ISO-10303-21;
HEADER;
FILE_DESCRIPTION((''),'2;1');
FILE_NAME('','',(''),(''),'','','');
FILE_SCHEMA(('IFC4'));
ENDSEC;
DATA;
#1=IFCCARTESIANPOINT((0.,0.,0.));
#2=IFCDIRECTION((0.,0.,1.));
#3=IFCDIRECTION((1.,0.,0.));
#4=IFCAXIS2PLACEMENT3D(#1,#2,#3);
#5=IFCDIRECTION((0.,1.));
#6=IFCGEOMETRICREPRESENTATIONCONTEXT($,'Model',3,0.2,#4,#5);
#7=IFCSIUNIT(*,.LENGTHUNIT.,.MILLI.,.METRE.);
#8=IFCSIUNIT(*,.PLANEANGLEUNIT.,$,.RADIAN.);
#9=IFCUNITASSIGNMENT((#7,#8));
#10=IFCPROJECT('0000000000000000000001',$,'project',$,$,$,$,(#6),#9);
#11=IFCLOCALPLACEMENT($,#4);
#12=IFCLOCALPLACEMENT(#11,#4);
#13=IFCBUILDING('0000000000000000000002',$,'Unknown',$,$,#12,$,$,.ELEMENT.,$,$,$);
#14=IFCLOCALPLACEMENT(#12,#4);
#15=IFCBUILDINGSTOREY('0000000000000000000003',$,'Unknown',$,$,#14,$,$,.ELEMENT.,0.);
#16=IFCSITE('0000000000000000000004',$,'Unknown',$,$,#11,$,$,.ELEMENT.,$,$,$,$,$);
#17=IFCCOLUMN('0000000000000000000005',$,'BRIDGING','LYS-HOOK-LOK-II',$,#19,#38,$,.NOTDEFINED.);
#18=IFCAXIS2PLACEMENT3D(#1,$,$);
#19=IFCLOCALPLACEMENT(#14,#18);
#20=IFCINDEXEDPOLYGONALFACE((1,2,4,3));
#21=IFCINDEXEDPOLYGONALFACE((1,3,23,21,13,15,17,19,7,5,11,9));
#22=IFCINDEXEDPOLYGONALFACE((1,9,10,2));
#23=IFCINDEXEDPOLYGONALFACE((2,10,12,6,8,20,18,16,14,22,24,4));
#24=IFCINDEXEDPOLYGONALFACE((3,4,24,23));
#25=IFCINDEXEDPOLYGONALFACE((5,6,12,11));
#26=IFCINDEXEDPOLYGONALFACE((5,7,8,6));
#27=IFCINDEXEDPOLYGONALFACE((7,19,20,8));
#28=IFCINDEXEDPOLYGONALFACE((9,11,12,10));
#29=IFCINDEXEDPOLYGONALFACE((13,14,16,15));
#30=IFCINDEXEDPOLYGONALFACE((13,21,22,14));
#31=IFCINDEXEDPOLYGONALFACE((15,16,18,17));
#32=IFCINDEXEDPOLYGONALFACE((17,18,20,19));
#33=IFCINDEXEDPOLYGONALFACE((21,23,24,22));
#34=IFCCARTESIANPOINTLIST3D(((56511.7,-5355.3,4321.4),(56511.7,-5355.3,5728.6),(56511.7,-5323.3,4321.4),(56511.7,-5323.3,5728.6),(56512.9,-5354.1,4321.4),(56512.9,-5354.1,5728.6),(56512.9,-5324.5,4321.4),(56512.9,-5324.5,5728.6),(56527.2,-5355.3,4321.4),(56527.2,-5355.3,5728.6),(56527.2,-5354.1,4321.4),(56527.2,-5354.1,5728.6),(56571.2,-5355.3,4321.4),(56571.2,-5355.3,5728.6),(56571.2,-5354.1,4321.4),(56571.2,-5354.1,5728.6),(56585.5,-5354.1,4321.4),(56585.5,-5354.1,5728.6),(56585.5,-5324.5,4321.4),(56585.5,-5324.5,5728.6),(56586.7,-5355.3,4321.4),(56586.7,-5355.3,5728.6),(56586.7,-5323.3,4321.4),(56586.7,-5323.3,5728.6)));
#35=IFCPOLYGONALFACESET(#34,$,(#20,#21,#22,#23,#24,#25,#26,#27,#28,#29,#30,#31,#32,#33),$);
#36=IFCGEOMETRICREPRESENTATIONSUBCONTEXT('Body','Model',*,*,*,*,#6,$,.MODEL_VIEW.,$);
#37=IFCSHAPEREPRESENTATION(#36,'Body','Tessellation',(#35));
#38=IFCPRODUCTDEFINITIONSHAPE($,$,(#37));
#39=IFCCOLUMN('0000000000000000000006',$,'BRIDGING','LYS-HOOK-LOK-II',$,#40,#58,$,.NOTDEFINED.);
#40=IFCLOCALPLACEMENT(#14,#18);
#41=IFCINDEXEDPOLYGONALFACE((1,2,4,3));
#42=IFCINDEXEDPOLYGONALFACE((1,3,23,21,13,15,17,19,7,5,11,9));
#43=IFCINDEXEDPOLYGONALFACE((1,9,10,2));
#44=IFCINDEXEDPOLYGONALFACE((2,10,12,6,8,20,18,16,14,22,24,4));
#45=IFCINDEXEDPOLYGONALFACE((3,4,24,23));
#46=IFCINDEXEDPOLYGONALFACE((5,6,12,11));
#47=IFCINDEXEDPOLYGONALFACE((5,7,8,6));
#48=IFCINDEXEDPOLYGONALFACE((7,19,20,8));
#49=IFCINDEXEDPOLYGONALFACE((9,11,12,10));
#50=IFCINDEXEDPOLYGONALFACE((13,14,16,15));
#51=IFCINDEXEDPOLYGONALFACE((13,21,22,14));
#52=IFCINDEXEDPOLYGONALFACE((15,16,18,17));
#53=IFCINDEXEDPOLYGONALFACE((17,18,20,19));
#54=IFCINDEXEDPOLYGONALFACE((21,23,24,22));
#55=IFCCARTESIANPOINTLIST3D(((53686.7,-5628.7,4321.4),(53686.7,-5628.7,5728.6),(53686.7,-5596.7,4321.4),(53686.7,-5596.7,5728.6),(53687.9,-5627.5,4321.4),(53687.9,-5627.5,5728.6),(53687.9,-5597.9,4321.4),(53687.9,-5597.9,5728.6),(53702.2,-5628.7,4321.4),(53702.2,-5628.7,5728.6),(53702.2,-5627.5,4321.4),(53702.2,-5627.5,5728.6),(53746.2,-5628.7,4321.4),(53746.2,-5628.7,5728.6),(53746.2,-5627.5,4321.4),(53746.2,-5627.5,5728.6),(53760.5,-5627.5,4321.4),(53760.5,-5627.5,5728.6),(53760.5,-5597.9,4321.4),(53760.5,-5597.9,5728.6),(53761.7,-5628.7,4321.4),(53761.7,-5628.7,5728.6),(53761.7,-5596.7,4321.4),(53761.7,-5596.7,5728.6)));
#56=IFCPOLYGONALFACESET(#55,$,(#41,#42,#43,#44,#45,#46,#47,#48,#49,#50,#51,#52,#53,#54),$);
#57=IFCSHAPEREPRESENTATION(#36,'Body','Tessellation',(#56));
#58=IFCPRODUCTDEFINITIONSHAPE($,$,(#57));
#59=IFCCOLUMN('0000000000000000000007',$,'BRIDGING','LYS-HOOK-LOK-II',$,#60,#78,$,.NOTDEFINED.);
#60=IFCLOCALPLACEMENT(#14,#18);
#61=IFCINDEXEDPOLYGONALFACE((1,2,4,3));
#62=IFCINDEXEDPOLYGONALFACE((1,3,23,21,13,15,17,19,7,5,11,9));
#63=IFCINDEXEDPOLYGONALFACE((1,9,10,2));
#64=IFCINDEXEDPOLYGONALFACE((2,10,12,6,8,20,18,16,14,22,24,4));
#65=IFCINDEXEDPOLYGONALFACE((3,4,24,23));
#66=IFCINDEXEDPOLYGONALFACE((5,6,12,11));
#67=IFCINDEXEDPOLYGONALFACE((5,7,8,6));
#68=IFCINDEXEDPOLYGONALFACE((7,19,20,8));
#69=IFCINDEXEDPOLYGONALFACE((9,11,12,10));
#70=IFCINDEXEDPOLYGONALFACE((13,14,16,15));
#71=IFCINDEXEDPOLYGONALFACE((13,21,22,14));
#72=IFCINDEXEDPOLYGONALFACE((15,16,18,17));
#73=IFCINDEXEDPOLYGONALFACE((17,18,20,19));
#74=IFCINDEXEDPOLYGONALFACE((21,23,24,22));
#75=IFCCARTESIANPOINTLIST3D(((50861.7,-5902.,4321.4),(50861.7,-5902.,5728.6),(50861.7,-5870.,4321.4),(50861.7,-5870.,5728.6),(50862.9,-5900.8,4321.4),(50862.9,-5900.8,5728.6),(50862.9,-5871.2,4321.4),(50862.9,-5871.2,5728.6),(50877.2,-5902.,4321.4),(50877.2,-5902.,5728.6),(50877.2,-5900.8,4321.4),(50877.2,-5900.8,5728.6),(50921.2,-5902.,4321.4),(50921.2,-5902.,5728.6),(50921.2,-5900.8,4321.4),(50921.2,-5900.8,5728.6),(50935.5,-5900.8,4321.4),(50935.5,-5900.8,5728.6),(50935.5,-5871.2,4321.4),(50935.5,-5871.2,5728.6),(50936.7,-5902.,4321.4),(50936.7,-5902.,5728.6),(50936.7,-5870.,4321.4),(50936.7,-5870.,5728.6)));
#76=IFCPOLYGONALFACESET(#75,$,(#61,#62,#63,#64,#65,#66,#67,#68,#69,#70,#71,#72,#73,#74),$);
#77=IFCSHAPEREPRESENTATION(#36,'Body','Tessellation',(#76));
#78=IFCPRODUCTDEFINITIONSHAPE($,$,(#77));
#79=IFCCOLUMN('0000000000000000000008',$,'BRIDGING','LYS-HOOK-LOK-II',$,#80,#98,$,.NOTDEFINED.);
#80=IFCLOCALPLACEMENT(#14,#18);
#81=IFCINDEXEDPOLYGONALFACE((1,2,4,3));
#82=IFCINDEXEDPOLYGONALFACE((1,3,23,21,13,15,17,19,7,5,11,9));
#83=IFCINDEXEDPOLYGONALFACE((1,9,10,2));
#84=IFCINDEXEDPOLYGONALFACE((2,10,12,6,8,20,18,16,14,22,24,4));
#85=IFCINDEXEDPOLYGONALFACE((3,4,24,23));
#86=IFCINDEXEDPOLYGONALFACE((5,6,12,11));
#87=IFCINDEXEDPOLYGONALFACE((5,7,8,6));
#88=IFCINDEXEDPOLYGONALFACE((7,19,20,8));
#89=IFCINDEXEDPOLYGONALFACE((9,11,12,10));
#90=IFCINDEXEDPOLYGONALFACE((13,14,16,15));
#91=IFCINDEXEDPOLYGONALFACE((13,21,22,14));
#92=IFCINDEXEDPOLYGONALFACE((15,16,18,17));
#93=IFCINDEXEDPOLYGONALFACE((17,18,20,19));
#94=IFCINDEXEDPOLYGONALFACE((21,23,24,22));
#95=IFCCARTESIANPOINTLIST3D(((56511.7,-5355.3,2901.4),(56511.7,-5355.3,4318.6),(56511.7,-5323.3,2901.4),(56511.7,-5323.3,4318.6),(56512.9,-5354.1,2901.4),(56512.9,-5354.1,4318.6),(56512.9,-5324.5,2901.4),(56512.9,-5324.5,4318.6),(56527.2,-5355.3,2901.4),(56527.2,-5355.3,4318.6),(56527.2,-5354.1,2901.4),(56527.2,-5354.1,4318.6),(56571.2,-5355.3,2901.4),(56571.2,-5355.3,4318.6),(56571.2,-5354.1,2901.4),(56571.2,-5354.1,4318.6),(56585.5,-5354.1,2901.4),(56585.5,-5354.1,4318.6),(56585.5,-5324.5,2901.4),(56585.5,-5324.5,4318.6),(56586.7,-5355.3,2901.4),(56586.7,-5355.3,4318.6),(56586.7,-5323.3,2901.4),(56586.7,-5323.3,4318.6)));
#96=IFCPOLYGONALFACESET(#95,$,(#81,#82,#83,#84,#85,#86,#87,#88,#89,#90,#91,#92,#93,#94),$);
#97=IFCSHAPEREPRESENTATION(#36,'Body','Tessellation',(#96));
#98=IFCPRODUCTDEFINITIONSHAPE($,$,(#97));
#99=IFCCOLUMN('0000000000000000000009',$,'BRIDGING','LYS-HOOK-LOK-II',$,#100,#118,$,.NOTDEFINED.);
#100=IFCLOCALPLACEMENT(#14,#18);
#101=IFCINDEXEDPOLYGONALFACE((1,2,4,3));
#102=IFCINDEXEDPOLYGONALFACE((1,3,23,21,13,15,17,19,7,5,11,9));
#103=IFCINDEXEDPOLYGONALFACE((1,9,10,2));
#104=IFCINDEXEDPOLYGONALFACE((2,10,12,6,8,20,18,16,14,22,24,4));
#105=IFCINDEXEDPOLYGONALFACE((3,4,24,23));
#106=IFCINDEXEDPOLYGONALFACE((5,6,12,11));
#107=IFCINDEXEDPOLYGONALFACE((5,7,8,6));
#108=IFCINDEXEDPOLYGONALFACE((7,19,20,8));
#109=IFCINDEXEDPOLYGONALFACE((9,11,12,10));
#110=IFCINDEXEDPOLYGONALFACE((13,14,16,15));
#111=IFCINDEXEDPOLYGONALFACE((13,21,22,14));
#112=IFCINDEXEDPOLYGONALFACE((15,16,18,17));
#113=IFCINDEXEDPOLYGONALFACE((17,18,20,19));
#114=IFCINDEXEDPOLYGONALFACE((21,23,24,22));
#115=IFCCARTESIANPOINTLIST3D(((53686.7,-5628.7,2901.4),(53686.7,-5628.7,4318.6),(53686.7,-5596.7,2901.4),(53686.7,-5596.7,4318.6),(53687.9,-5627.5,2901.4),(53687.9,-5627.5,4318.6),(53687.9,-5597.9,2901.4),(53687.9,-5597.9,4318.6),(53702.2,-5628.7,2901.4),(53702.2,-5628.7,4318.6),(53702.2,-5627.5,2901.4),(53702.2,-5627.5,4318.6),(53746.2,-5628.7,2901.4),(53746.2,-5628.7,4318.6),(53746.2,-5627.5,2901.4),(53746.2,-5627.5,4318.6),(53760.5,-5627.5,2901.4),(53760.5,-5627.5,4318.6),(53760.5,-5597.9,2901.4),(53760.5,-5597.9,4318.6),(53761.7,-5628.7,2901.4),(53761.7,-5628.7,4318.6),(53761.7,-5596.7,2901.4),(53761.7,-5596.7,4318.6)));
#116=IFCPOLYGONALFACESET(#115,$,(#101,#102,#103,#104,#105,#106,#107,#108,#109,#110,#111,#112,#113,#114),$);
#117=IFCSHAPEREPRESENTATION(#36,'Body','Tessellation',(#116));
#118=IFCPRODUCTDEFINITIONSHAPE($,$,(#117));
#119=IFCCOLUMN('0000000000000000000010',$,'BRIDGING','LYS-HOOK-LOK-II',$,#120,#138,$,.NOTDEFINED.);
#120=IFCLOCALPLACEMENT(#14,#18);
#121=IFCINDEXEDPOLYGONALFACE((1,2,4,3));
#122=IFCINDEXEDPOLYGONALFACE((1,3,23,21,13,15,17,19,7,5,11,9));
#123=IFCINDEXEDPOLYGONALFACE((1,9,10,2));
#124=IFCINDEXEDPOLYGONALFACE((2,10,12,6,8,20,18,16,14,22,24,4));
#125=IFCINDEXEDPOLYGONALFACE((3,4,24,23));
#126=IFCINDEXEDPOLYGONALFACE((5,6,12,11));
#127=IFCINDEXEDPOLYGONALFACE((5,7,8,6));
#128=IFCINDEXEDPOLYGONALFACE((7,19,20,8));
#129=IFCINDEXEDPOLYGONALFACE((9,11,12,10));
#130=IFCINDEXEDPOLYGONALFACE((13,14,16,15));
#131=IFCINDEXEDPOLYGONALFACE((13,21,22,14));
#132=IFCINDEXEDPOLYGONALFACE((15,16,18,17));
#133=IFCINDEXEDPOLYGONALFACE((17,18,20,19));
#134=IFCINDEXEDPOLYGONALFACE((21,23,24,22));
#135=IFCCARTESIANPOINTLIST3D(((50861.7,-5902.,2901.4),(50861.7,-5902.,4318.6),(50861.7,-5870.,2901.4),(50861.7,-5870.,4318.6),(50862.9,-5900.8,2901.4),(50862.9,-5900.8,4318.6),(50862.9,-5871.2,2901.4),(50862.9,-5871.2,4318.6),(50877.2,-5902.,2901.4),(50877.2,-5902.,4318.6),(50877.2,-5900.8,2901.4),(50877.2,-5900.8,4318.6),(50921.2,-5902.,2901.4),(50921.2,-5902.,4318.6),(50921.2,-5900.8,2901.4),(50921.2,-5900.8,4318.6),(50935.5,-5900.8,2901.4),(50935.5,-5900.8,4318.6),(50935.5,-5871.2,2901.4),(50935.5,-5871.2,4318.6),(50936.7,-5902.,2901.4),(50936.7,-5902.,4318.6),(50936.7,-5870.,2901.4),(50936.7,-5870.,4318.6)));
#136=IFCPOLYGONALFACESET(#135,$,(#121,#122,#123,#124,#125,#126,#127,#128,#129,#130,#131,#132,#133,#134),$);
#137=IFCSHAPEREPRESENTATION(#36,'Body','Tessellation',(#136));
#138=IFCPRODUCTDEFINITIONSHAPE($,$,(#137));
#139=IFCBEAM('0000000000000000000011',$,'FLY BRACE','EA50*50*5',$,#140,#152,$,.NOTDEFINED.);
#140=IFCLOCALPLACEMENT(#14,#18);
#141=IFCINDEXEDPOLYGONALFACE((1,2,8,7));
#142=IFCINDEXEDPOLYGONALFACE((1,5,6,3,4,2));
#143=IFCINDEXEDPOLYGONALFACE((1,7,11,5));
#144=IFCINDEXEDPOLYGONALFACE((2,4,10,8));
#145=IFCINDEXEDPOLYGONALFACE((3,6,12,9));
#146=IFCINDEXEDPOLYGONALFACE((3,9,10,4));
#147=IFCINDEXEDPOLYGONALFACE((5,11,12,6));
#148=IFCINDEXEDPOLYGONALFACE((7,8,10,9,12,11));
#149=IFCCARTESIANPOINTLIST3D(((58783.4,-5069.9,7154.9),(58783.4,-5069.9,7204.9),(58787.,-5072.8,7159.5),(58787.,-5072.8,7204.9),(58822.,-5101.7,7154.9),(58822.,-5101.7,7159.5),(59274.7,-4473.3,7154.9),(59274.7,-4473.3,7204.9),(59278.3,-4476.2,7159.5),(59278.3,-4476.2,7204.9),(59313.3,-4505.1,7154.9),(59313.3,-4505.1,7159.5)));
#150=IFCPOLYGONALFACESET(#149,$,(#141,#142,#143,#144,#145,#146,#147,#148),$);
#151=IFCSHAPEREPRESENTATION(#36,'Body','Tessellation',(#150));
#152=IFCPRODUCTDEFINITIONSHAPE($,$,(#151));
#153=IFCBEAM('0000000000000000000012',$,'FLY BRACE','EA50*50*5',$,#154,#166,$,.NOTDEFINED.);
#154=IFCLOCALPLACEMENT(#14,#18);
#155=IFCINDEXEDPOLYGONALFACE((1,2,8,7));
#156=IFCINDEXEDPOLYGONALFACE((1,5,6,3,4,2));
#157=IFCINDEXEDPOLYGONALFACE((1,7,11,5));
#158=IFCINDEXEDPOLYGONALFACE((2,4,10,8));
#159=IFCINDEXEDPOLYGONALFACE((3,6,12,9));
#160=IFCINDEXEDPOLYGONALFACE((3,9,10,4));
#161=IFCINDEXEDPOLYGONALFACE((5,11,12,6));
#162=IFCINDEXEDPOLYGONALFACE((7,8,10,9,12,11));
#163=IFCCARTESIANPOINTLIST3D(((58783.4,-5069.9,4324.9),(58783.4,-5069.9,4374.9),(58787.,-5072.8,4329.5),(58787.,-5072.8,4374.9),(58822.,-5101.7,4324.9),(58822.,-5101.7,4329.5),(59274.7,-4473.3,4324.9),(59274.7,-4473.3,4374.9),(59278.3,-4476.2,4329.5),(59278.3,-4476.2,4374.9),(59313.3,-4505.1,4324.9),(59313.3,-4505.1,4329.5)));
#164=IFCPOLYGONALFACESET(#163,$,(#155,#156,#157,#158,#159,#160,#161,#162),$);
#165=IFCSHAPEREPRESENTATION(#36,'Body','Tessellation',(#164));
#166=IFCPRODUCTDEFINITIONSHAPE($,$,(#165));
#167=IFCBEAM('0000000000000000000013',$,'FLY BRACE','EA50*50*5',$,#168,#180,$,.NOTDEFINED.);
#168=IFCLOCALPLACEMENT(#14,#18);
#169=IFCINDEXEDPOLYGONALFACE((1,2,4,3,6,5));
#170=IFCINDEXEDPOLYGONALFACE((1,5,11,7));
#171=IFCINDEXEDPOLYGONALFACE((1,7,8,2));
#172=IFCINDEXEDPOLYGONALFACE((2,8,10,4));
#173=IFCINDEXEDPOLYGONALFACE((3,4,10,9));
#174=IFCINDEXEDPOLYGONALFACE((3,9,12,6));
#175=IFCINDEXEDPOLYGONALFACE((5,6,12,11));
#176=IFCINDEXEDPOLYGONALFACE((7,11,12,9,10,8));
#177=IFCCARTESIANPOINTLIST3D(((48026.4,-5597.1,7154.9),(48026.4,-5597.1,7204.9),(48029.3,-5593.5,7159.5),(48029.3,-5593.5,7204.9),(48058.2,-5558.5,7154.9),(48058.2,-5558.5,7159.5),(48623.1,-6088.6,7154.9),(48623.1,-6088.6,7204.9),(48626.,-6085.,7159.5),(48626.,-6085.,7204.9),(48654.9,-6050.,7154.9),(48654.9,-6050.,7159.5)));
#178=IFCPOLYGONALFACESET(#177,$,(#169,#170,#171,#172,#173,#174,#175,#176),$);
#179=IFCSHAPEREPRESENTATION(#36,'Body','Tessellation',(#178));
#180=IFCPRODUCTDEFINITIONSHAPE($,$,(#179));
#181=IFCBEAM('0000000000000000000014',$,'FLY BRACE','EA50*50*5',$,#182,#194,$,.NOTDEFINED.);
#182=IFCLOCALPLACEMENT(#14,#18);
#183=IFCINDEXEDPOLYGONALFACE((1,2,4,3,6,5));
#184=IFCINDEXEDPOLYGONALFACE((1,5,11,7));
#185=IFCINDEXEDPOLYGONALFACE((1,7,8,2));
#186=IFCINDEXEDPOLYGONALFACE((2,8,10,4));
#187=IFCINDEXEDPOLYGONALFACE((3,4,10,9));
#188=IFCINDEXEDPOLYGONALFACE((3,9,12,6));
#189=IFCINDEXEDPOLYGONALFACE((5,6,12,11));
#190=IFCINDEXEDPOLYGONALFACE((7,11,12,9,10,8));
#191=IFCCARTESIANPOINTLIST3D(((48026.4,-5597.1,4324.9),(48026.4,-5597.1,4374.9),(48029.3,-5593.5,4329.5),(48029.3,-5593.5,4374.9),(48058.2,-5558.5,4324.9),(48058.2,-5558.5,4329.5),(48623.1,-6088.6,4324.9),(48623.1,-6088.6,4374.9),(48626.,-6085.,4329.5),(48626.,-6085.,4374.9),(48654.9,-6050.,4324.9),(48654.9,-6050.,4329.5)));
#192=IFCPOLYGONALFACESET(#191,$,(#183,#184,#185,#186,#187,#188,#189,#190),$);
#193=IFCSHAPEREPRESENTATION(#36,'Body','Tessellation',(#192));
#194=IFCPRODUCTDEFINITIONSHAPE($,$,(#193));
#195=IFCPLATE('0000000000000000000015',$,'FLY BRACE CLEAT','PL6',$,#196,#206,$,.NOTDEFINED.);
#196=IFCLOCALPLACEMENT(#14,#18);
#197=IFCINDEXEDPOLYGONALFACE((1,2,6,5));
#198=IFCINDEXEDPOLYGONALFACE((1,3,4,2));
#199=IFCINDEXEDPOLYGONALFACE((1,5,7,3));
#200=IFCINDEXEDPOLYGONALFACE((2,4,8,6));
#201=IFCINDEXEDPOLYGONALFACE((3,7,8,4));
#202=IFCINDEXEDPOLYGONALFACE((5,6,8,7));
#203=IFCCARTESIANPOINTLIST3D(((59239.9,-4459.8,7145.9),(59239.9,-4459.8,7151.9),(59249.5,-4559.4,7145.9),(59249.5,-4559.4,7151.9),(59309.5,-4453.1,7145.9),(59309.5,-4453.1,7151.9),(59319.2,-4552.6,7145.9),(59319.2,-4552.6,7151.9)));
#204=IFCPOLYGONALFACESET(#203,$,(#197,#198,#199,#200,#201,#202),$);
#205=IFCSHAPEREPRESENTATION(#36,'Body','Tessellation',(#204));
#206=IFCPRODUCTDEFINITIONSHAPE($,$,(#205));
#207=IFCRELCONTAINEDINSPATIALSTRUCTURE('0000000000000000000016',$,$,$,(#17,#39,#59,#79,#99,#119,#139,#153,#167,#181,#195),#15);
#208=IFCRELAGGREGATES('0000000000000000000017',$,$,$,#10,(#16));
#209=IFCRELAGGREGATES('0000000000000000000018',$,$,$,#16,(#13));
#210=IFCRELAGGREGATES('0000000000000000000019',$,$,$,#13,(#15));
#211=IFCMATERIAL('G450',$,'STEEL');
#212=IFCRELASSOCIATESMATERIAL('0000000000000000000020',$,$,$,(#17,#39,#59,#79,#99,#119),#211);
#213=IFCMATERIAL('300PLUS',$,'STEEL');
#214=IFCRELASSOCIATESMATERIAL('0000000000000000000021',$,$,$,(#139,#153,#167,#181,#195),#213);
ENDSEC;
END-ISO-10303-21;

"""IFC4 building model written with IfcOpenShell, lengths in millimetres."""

from ifc_helpers import new_model, si_unit, direction, frame, origin_with_axes, place, context, subcontext, project, spatial, line, indexed_curve, outline, extrude, material, element, save


model = new_model("IFC4")

# Units and contexts
model_context = context("Model", 3, precision=0.2, world=origin_with_axes(), true_north=direction((0.0, 1.0)))
body_context = subcontext(model_context, "Body", "Model", "MODEL_VIEW")
ifc_project = project(units=[si_unit("LENGTHUNIT", "METRE", prefix="MILLI"), si_unit("PLANEANGLEUNIT", "RADIAN")], contexts=[model_context])

# Site, building, storey
site_placement = place(None, origin_with_axes())
site = spatial("IfcSite", under=ifc_project, at=site_placement, Name="Unknown", CompositionType="ELEMENT")
building_placement = place(site_placement, origin_with_axes())
building = spatial("IfcBuilding", under=site, at=building_placement, Name="Unknown", CompositionType="ELEMENT")
storey_placement = place(building_placement, origin_with_axes())
storey = spatial("IfcBuildingStorey", under=building, at=storey_placement, Name="Unknown", CompositionType="ELEMENT", Elevation=0.0)

# Columns
ifc_material_1 = material(Name="G450", Category="STEEL")
for number, where, z_axis, x_axis, name in (
    (1, (56549.2, -5339.3, 4321.4), (0.0, -1.0, 0.0), (0.0, 0.0, 1.0), "BRIDGING"),
    (2, (53724.2, -5612.7, 4321.4), (0.0, -1.0, 0.0), (0.0, 0.0, 1.0), "BRIDGING"),
    (3, (50899.2, -5886.0, 4321.4), (0.0, -1.0, 0.0), (0.0, 0.0, 1.0), "BRIDGING"),
):
    element("IfcColumn", number, at=place(storey_placement, frame(where, z_axis=z_axis, x_axis=x_axis)), inside=storey, material=ifc_material_1, Name=name, Description="LYS-HOOK-LOK-II", PredefinedType="NOTDEFINED", context=body_context, shape_type="SolidModel", body=[
        extrude(outline(indexed_curve([(16.0, -37.5), (16.0, -22.0), (14.8, -22.0), (14.8, -36.3), (-14.8, -36.3), (-14.8, 36.3), (14.8, 36.3), (14.8, 22.0), (16.0, 22.0), (16.0, 37.5), (-16.0, 37.5), (-16.0, -37.5)], segments=[line(1, 2, 3, 4, 5, 6, 7, 8, 9, 10, 11, 12, 1)])), frame((0.0, 0.0, 0.0), z_axis=(-1.0, 0.0, 0.0), x_axis=(0.0, 0.0, 1.0)), (0.0, 0.0, -1.0), 1407.2),
    ])
for number, where, z_axis, x_axis, name in (
    (4, (56549.2, -5339.3, 2901.4), (0.0, -1.0, 0.0), (0.0, 0.0, 1.0), "BRIDGING"),
    (5, (53724.2, -5612.7, 2901.4), (0.0, -1.0, 0.0), (0.0, 0.0, 1.0), "BRIDGING"),
    (6, (50899.2, -5886.0, 2901.4), (0.0, -1.0, 0.0), (0.0, 0.0, 1.0), "BRIDGING"),
):
    element("IfcColumn", number, at=place(storey_placement, frame(where, z_axis=z_axis, x_axis=x_axis)), inside=storey, material=ifc_material_1, Name=name, Description="LYS-HOOK-LOK-II", PredefinedType="NOTDEFINED", context=body_context, shape_type="SolidModel", body=[
        extrude(outline(indexed_curve([(16.0, -37.5), (16.0, -22.0), (14.8, -22.0), (14.8, -36.3), (-14.8, -36.3), (-14.8, 36.3), (14.8, 36.3), (14.8, 22.0), (16.0, 22.0), (16.0, 37.5), (-16.0, 37.5), (-16.0, -37.5)], segments=[line(1, 2, 3, 4, 5, 6, 7, 8, 9, 10, 11, 12, 1)])), frame((0.0, 0.0, 0.0), z_axis=(-1.0, 0.0, 0.0), x_axis=(0.0, 0.0, 1.0)), (0.0, 0.0, -1.0), 1417.2),
    ])

# Beams
ifc_material_2 = material(Name="300PLUS", Category="STEEL")
for number, where, z_axis, x_axis, name in (
    (7, (59294.0, -4489.2, 7179.9), (0.0, 0.0, 1.0), (-0.635694, -0.771941, 0.0), "FLY BRACE"),
    (8, (59294.0, -4489.2, 4349.9), (0.0, 0.0, 1.0), (-0.635694, -0.771941, 0.0), "FLY BRACE"),
):
    element("IfcBeam", number, at=place(storey_placement, frame(where, z_axis=z_axis, x_axis=x_axis)), inside=storey, material=ifc_material_2, Name=name, Description="EA50*50*5", PredefinedType="NOTDEFINED", context=body_context, shape_type="SolidModel", body=[
        extrude(outline(indexed_curve([(-25.0, -25.0), (25.0, -25.0), (25.0, -20.4), (-20.4, -20.4), (-20.4, 25.0), (-25.0, 25.0)], segments=[line(1, 2, 3, 4, 5, 6, 1)])), frame((0.0, 0.0, 0.0), z_axis=(-1.0, 0.0, 0.0), x_axis=(0.0, 0.0, 1.0)), (0.0, 0.0, -1.0), 772.9),
    ])
for number, where, z_axis, x_axis, name in (
    (9, (48042.3, -5577.8, 7179.9), (0.0, 0.0, 1.0), (0.771867, -0.635784, 0.0), "FLY BRACE"),
    (10, (48042.3, -5577.8, 4349.9), (0.0, 0.0, 1.0), (0.771867, -0.635784, 0.0), "FLY BRACE"),
):
    element("IfcBeam", number, at=place(storey_placement, frame(where, z_axis=z_axis, x_axis=x_axis)), inside=storey, material=ifc_material_2, Name=name, Description="EA50*50*5", PredefinedType="NOTDEFINED", context=body_context, shape_type="SolidModel", body=[
        extrude(outline(indexed_curve([(-25.0, -25.0), (25.0, -25.0), (25.0, -20.4), (-20.4, -20.4), (-20.4, 25.0), (-25.0, 25.0)], segments=[line(1, 2, 3, 4, 5, 6, 1)])), frame((0.0, 0.0, 0.0), z_axis=(-1.0, 0.0, 0.0), x_axis=(0.0, 0.0, 1.0)), (0.0, 0.0, -1.0), 773.1),
    ])

# Plate
plate_1_placement = place(storey_placement, frame((59309.5, -4453.1, 7148.9), z_axis=(0.0, 0.0, 1.0), x_axis=(-0.995399, -0.095821, 0.0)))
element("IfcPlate", 11, at=plate_1_placement, inside=storey, material=ifc_material_2, Name="FLY BRACE CLEAT", Description="PL6", PredefinedType="NOTDEFINED", context=body_context, shape_type="SolidModel", body=[
    extrude(outline(indexed_curve([(0.0, 0.0), (69.9, 0.0), (69.9, 100.1), (-0.1, 100.0)], segments=[line(1, 2, 3, 4, 1)])), frame((0.0, 0.0, 3.0), z_axis=(0.0, 0.0, 1.0), x_axis=(1.0, 0.0, 0.0)), (0.0, 0.0, -1.0), 6.0),
])

save(model, "model.ifc")
